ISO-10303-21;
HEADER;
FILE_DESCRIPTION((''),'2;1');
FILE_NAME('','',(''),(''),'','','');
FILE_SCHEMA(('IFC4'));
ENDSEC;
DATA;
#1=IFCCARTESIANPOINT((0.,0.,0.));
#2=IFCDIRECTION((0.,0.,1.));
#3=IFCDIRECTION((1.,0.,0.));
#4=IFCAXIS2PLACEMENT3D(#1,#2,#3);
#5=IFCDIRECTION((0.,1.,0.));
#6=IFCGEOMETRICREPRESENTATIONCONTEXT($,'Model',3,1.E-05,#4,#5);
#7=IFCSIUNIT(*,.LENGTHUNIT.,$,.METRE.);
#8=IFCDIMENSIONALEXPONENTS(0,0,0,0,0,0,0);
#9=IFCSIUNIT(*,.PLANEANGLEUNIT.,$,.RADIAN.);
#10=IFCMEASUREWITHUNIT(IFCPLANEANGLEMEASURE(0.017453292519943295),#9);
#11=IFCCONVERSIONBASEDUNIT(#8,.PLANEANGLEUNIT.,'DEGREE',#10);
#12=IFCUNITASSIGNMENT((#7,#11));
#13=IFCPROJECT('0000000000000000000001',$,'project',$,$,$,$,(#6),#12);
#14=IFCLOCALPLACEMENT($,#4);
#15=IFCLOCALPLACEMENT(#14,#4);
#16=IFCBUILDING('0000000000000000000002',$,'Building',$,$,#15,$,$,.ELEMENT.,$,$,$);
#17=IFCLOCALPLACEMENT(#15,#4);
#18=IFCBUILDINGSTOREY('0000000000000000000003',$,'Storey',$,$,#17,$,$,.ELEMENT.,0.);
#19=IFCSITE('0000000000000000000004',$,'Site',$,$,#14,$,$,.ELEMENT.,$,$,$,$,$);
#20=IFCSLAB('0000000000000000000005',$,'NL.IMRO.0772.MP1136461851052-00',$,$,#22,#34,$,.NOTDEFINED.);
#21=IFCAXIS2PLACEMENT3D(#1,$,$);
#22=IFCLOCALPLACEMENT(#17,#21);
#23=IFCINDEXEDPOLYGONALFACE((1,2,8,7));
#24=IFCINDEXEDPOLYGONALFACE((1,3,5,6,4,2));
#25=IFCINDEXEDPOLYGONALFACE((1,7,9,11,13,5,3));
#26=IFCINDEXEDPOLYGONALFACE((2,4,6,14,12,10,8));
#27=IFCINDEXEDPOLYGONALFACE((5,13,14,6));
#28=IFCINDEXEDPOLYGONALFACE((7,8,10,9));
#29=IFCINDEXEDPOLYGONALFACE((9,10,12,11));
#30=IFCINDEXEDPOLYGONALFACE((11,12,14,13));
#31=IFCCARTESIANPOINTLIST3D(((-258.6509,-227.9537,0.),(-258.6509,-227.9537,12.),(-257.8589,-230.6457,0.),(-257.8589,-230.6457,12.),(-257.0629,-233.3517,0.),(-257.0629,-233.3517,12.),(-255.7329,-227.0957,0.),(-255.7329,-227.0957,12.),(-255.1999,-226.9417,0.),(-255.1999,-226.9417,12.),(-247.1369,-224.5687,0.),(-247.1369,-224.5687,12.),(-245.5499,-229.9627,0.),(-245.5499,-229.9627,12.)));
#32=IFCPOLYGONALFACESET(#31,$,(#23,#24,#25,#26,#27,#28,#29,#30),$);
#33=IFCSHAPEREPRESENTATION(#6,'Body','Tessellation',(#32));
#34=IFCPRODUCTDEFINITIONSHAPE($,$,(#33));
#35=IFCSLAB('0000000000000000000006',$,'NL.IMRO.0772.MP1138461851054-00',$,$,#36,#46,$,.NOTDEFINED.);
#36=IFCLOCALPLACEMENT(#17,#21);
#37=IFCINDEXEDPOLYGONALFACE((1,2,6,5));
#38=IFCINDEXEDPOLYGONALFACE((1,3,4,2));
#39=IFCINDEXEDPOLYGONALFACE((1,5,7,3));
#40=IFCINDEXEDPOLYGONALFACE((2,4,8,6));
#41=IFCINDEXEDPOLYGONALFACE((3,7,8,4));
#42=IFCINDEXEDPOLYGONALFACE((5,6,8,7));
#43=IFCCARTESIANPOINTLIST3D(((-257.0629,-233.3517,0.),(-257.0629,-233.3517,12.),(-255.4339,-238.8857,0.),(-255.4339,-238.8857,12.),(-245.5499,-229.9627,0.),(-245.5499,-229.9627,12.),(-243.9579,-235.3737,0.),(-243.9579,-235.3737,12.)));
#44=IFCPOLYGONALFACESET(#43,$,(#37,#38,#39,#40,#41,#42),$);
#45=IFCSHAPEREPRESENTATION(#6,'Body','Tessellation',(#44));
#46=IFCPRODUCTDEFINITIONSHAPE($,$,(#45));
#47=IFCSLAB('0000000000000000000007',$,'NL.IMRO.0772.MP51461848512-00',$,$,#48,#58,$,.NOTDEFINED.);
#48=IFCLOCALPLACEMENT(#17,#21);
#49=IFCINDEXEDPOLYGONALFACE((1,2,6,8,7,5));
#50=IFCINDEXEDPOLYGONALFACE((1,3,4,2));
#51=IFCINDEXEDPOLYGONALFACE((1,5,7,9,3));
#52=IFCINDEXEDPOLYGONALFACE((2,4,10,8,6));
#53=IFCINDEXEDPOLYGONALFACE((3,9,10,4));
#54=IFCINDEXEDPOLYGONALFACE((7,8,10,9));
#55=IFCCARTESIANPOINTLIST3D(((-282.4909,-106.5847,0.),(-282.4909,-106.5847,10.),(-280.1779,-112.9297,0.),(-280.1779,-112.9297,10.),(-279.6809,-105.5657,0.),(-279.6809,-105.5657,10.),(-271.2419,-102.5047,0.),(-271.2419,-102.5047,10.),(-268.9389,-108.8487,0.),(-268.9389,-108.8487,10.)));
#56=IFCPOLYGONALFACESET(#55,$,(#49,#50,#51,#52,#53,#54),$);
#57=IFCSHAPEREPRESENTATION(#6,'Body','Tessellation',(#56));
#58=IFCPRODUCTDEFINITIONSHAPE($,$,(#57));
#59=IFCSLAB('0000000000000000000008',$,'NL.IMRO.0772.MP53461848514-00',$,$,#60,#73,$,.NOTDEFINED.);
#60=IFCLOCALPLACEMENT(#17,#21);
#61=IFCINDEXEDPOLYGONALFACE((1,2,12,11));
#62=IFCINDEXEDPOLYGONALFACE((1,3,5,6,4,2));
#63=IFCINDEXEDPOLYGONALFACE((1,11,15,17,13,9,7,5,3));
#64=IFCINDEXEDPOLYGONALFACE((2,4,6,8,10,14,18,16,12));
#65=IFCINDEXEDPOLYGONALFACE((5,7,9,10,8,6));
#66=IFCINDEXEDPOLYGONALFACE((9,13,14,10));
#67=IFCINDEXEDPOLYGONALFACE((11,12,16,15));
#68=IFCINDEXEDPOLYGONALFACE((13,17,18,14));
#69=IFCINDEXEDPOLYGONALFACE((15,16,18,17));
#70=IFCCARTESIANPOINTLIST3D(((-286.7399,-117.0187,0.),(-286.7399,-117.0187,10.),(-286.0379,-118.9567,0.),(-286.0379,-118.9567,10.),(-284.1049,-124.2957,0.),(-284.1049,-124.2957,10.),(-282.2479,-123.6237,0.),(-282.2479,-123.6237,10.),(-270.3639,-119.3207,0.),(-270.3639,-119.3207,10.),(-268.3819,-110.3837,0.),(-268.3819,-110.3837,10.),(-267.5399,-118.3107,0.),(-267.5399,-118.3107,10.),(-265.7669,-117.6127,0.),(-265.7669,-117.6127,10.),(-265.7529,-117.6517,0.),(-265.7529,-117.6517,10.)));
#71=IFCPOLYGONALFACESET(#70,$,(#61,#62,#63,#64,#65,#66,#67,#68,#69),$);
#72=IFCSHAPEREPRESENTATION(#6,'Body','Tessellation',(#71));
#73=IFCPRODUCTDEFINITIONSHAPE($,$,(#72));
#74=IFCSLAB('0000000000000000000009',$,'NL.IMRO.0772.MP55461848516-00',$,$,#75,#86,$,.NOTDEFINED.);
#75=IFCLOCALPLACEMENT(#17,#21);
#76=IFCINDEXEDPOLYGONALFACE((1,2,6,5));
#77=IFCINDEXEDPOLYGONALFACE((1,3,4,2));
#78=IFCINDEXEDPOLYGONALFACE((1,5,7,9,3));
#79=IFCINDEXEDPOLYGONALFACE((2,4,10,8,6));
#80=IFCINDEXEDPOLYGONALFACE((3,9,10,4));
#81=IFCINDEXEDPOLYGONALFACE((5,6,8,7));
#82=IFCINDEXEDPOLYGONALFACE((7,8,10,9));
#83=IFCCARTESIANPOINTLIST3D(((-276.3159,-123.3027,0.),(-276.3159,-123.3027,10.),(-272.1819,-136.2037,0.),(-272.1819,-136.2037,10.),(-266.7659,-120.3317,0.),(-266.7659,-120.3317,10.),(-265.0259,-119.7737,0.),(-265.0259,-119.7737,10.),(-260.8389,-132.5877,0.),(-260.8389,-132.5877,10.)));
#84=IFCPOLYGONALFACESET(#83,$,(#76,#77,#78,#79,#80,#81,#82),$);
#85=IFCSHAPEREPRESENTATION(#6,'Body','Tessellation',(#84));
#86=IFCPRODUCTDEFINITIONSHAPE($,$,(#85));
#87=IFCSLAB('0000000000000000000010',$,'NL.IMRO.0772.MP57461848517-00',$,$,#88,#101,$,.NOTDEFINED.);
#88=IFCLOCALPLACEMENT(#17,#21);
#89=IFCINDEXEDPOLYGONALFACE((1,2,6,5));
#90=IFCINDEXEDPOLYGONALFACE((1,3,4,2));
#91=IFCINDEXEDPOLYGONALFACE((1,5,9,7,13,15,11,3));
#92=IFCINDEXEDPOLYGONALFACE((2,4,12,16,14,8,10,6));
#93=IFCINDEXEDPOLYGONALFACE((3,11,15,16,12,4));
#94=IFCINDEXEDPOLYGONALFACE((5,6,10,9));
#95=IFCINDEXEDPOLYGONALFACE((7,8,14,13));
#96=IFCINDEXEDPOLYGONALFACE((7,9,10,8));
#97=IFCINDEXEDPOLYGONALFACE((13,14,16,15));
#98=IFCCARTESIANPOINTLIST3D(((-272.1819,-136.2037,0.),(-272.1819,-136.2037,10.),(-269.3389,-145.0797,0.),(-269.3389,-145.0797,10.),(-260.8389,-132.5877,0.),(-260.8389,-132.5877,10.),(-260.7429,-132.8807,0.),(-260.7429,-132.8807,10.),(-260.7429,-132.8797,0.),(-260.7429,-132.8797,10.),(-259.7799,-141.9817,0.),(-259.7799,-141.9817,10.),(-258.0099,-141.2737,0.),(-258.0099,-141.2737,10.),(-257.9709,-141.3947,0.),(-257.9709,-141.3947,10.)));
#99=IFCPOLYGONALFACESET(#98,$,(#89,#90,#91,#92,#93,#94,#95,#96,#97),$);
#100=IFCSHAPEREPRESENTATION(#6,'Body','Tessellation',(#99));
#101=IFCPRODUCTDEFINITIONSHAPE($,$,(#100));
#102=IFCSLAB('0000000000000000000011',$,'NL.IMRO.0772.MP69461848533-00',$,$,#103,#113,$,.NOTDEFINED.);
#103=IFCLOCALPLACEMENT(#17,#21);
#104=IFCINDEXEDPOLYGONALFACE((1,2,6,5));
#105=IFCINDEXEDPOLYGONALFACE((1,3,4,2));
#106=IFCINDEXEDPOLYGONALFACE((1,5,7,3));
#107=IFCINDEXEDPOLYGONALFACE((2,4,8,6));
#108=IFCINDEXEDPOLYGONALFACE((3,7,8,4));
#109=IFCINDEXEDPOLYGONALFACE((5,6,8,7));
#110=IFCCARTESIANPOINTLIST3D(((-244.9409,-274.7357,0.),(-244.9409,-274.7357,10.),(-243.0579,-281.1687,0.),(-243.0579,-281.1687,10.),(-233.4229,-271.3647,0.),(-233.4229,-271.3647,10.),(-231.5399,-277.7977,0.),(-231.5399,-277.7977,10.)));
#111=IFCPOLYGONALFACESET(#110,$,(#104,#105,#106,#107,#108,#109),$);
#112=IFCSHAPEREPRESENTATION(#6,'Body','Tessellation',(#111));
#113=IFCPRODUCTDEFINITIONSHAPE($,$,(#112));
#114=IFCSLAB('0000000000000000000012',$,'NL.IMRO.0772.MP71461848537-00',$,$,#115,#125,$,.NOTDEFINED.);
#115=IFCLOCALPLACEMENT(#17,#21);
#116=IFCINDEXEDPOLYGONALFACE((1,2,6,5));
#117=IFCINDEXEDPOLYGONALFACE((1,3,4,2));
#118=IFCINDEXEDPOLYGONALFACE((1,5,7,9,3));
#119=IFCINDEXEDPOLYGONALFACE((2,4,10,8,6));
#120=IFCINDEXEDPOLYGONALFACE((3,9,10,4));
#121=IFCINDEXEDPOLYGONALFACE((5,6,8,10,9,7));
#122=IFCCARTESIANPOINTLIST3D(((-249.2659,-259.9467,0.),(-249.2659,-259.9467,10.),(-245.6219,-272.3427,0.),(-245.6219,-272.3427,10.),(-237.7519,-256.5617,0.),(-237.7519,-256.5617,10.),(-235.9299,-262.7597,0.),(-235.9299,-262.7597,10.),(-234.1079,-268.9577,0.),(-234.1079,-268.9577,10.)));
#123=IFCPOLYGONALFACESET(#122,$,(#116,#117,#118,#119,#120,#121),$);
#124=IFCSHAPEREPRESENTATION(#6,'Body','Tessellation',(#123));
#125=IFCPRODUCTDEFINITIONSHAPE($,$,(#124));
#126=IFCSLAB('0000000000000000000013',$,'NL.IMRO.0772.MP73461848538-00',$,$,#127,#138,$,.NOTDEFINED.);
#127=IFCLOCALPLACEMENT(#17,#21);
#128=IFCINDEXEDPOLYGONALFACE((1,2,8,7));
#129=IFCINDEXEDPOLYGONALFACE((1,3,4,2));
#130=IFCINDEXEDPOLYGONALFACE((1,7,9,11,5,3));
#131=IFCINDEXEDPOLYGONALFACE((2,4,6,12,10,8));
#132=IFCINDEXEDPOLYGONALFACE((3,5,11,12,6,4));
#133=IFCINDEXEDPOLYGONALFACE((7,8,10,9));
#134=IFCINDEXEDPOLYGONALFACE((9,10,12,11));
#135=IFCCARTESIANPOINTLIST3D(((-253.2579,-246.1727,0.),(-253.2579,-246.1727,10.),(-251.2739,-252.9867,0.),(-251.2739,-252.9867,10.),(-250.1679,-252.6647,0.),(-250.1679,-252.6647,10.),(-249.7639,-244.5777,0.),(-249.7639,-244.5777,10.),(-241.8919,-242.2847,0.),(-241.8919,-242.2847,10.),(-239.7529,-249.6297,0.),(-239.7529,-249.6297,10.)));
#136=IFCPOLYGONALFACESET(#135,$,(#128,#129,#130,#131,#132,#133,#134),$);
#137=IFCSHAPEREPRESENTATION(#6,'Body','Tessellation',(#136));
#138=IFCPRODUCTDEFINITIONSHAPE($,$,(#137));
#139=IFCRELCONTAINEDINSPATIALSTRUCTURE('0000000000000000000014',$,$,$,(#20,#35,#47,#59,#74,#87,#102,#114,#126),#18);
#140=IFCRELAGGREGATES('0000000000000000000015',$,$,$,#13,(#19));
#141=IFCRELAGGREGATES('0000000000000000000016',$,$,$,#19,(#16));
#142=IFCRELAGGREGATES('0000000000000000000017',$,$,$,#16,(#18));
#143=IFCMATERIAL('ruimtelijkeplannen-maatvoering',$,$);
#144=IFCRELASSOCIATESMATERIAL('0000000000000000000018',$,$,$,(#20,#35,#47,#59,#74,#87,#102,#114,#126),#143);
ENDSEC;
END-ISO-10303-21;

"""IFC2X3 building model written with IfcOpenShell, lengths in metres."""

from ifc_helpers import new_model, entity, si_unit, converted_unit, direction, origin_with_axes, place, context, project, spatial, polyline, outline, extrude, material, element, save


model = new_model("IFC2X3")

# Units and contexts
model_context = context("Model", 3, precision=1e-05, world=origin_with_axes(), true_north=direction((0.0, 1.0, 0.0)))
ifc_project = project(units=[si_unit("LENGTHUNIT", "METRE"), converted_unit("PLANEANGLEUNIT", "DEGREE", entity("IfcPlaneAngleMeasure", 0.017453292519943295), si_unit("PLANEANGLEUNIT", "RADIAN"), dimensions=[0, 0, 0, 0, 0, 0, 0])], contexts=[model_context])

# Site, building, storey
site_placement = place(None, origin_with_axes())
site = spatial("IfcSite", under=ifc_project, at=site_placement, Name="Site", CompositionType="ELEMENT")
building_placement = place(site_placement, origin_with_axes())
building = spatial("IfcBuilding", under=site, at=building_placement, Name="Building", CompositionType="ELEMENT")
storey_placement = place(building_placement, origin_with_axes())
storey = spatial("IfcBuildingStorey", under=building, at=storey_placement, Name="Storey", CompositionType="ELEMENT", Elevation=0.0)

# Slabs
ifc_material = material(Name="ruimtelijkeplannen-maatvoering")
slab_1_placement = place(storey_placement, origin_with_axes())
element("IfcSlab", 1, at=slab_1_placement, inside=storey, material=ifc_material, Name="NL.IMRO.0772.MP1136461851052-00", PredefinedType="NOTDEFINED", context=model_context, shape_type="SweptSolid", body=[
    extrude(outline(polyline([(-257.0629, -233.3517), (-257.8589, -230.6457), (-258.6509, -227.9537), (-255.7329, -227.0957), (-255.1999, -226.9417), (-247.1369, -224.5687), (-245.5499, -229.9627), (-257.0629, -233.3517)])), origin_with_axes(), (0.0, 0.0, 1.0), 12.0),
])
slab_2_placement = place(storey_placement, origin_with_axes())
element("IfcSlab", 2, at=slab_2_placement, inside=storey, material=ifc_material, Name="NL.IMRO.0772.MP1138461851054-00", PredefinedType="NOTDEFINED", context=model_context, shape_type="SweptSolid", body=[
    extrude(outline(polyline([(-243.9579, -235.3737), (-255.4339, -238.8857), (-257.0629, -233.3517), (-245.5499, -229.9627), (-243.9579, -235.3737)])), origin_with_axes(), (0.0, 0.0, 1.0), 12.0),
])
slab_3_placement = place(storey_placement, origin_with_axes())
element("IfcSlab", 3, at=slab_3_placement, inside=storey, material=ifc_material, Name="NL.IMRO.0772.MP51461848512-00", PredefinedType="NOTDEFINED", context=model_context, shape_type="SweptSolid", body=[
    extrude(outline(polyline([(-280.1779, -112.9297), (-282.4909, -106.5847), (-279.6809, -105.5657), (-271.2419, -102.5047), (-268.9389, -108.8487), (-280.1779, -112.9297)])), origin_with_axes(), (0.0, 0.0, 1.0), 10.0),
])
slab_4_placement = place(storey_placement, origin_with_axes())
element("IfcSlab", 4, at=slab_4_placement, inside=storey, material=ifc_material, Name="NL.IMRO.0772.MP53461848514-00", PredefinedType="NOTDEFINED", context=model_context, shape_type="SweptSolid", body=[
    extrude(outline(polyline([(-267.5399, -118.3107), (-270.3639, -119.3207), (-282.2479, -123.6237), (-284.1049, -124.2957), (-286.0379, -118.9567), (-286.7399, -117.0187), (-268.3819, -110.3837), (-265.7669, -117.6127), (-265.7529, -117.6517), (-267.5399, -118.3107)])), origin_with_axes(), (0.0, 0.0, 1.0), 10.0),
])
slab_5_placement = place(storey_placement, origin_with_axes())
element("IfcSlab", 5, at=slab_5_placement, inside=storey, material=ifc_material, Name="NL.IMRO.0772.MP55461848516-00", PredefinedType="NOTDEFINED", context=model_context, shape_type="SweptSolid", body=[
    extrude(outline(polyline([(-272.1819, -136.2037), (-276.3159, -123.3027), (-266.7659, -120.3317), (-265.0259, -119.7737), (-260.8389, -132.5877), (-272.1819, -136.2037)])), origin_with_axes(), (0.0, 0.0, 1.0), 10.0),
])
slab_6_placement = place(storey_placement, origin_with_axes())
element("IfcSlab", 6, at=slab_6_placement, inside=storey, material=ifc_material, Name="NL.IMRO.0772.MP57461848517-00", PredefinedType="NOTDEFINED", context=model_context, shape_type="SweptSolid", body=[
    extrude(outline(polyline([(-257.9709, -141.3947), (-259.7799, -141.9817), (-269.3389, -145.0797), (-272.1819, -136.2037), (-260.8389, -132.5877), (-260.7429, -132.8797), (-260.7429, -132.8807), (-258.0099, -141.2737), (-257.9709, -141.3947)])), origin_with_axes(), (0.0, 0.0, 1.0), 10.0),
])
slab_7_placement = place(storey_placement, origin_with_axes())
element("IfcSlab", 7, at=slab_7_placement, inside=storey, material=ifc_material, Name="NL.IMRO.0772.MP69461848533-00", PredefinedType="NOTDEFINED", context=model_context, shape_type="SweptSolid", body=[
    extrude(outline(polyline([(-244.9409, -274.7357), (-233.4229, -271.3647), (-231.5399, -277.7977), (-243.0579, -281.1687), (-244.9409, -274.7357)])), origin_with_axes(), (0.0, 0.0, 1.0), 10.0),
])
slab_8_placement = place(storey_placement, origin_with_axes())
element("IfcSlab", 8, at=slab_8_placement, inside=storey, material=ifc_material, Name="NL.IMRO.0772.MP71461848537-00", PredefinedType="NOTDEFINED", context=model_context, shape_type="SweptSolid", body=[
    extrude(outline(polyline([(-235.9299, -262.7597), (-234.1079, -268.9577), (-245.6219, -272.3427), (-249.2659, -259.9467), (-237.7519, -256.5617), (-235.9299, -262.7597)])), origin_with_axes(), (0.0, 0.0, 1.0), 10.0),
])
slab_9_placement = place(storey_placement, origin_with_axes())
element("IfcSlab", 9, at=slab_9_placement, inside=storey, material=ifc_material, Name="NL.IMRO.0772.MP73461848538-00", PredefinedType="NOTDEFINED", context=model_context, shape_type="SweptSolid", body=[
    extrude(outline(polyline([(-239.7529, -249.6297), (-250.1679, -252.6647), (-251.2739, -252.9867), (-253.2579, -246.1727), (-249.7639, -244.5777), (-241.8919, -242.2847), (-239.7529, -249.6297)])), origin_with_axes(), (0.0, 0.0, 1.0), 10.0),
])

save(model, "model.ifc")
